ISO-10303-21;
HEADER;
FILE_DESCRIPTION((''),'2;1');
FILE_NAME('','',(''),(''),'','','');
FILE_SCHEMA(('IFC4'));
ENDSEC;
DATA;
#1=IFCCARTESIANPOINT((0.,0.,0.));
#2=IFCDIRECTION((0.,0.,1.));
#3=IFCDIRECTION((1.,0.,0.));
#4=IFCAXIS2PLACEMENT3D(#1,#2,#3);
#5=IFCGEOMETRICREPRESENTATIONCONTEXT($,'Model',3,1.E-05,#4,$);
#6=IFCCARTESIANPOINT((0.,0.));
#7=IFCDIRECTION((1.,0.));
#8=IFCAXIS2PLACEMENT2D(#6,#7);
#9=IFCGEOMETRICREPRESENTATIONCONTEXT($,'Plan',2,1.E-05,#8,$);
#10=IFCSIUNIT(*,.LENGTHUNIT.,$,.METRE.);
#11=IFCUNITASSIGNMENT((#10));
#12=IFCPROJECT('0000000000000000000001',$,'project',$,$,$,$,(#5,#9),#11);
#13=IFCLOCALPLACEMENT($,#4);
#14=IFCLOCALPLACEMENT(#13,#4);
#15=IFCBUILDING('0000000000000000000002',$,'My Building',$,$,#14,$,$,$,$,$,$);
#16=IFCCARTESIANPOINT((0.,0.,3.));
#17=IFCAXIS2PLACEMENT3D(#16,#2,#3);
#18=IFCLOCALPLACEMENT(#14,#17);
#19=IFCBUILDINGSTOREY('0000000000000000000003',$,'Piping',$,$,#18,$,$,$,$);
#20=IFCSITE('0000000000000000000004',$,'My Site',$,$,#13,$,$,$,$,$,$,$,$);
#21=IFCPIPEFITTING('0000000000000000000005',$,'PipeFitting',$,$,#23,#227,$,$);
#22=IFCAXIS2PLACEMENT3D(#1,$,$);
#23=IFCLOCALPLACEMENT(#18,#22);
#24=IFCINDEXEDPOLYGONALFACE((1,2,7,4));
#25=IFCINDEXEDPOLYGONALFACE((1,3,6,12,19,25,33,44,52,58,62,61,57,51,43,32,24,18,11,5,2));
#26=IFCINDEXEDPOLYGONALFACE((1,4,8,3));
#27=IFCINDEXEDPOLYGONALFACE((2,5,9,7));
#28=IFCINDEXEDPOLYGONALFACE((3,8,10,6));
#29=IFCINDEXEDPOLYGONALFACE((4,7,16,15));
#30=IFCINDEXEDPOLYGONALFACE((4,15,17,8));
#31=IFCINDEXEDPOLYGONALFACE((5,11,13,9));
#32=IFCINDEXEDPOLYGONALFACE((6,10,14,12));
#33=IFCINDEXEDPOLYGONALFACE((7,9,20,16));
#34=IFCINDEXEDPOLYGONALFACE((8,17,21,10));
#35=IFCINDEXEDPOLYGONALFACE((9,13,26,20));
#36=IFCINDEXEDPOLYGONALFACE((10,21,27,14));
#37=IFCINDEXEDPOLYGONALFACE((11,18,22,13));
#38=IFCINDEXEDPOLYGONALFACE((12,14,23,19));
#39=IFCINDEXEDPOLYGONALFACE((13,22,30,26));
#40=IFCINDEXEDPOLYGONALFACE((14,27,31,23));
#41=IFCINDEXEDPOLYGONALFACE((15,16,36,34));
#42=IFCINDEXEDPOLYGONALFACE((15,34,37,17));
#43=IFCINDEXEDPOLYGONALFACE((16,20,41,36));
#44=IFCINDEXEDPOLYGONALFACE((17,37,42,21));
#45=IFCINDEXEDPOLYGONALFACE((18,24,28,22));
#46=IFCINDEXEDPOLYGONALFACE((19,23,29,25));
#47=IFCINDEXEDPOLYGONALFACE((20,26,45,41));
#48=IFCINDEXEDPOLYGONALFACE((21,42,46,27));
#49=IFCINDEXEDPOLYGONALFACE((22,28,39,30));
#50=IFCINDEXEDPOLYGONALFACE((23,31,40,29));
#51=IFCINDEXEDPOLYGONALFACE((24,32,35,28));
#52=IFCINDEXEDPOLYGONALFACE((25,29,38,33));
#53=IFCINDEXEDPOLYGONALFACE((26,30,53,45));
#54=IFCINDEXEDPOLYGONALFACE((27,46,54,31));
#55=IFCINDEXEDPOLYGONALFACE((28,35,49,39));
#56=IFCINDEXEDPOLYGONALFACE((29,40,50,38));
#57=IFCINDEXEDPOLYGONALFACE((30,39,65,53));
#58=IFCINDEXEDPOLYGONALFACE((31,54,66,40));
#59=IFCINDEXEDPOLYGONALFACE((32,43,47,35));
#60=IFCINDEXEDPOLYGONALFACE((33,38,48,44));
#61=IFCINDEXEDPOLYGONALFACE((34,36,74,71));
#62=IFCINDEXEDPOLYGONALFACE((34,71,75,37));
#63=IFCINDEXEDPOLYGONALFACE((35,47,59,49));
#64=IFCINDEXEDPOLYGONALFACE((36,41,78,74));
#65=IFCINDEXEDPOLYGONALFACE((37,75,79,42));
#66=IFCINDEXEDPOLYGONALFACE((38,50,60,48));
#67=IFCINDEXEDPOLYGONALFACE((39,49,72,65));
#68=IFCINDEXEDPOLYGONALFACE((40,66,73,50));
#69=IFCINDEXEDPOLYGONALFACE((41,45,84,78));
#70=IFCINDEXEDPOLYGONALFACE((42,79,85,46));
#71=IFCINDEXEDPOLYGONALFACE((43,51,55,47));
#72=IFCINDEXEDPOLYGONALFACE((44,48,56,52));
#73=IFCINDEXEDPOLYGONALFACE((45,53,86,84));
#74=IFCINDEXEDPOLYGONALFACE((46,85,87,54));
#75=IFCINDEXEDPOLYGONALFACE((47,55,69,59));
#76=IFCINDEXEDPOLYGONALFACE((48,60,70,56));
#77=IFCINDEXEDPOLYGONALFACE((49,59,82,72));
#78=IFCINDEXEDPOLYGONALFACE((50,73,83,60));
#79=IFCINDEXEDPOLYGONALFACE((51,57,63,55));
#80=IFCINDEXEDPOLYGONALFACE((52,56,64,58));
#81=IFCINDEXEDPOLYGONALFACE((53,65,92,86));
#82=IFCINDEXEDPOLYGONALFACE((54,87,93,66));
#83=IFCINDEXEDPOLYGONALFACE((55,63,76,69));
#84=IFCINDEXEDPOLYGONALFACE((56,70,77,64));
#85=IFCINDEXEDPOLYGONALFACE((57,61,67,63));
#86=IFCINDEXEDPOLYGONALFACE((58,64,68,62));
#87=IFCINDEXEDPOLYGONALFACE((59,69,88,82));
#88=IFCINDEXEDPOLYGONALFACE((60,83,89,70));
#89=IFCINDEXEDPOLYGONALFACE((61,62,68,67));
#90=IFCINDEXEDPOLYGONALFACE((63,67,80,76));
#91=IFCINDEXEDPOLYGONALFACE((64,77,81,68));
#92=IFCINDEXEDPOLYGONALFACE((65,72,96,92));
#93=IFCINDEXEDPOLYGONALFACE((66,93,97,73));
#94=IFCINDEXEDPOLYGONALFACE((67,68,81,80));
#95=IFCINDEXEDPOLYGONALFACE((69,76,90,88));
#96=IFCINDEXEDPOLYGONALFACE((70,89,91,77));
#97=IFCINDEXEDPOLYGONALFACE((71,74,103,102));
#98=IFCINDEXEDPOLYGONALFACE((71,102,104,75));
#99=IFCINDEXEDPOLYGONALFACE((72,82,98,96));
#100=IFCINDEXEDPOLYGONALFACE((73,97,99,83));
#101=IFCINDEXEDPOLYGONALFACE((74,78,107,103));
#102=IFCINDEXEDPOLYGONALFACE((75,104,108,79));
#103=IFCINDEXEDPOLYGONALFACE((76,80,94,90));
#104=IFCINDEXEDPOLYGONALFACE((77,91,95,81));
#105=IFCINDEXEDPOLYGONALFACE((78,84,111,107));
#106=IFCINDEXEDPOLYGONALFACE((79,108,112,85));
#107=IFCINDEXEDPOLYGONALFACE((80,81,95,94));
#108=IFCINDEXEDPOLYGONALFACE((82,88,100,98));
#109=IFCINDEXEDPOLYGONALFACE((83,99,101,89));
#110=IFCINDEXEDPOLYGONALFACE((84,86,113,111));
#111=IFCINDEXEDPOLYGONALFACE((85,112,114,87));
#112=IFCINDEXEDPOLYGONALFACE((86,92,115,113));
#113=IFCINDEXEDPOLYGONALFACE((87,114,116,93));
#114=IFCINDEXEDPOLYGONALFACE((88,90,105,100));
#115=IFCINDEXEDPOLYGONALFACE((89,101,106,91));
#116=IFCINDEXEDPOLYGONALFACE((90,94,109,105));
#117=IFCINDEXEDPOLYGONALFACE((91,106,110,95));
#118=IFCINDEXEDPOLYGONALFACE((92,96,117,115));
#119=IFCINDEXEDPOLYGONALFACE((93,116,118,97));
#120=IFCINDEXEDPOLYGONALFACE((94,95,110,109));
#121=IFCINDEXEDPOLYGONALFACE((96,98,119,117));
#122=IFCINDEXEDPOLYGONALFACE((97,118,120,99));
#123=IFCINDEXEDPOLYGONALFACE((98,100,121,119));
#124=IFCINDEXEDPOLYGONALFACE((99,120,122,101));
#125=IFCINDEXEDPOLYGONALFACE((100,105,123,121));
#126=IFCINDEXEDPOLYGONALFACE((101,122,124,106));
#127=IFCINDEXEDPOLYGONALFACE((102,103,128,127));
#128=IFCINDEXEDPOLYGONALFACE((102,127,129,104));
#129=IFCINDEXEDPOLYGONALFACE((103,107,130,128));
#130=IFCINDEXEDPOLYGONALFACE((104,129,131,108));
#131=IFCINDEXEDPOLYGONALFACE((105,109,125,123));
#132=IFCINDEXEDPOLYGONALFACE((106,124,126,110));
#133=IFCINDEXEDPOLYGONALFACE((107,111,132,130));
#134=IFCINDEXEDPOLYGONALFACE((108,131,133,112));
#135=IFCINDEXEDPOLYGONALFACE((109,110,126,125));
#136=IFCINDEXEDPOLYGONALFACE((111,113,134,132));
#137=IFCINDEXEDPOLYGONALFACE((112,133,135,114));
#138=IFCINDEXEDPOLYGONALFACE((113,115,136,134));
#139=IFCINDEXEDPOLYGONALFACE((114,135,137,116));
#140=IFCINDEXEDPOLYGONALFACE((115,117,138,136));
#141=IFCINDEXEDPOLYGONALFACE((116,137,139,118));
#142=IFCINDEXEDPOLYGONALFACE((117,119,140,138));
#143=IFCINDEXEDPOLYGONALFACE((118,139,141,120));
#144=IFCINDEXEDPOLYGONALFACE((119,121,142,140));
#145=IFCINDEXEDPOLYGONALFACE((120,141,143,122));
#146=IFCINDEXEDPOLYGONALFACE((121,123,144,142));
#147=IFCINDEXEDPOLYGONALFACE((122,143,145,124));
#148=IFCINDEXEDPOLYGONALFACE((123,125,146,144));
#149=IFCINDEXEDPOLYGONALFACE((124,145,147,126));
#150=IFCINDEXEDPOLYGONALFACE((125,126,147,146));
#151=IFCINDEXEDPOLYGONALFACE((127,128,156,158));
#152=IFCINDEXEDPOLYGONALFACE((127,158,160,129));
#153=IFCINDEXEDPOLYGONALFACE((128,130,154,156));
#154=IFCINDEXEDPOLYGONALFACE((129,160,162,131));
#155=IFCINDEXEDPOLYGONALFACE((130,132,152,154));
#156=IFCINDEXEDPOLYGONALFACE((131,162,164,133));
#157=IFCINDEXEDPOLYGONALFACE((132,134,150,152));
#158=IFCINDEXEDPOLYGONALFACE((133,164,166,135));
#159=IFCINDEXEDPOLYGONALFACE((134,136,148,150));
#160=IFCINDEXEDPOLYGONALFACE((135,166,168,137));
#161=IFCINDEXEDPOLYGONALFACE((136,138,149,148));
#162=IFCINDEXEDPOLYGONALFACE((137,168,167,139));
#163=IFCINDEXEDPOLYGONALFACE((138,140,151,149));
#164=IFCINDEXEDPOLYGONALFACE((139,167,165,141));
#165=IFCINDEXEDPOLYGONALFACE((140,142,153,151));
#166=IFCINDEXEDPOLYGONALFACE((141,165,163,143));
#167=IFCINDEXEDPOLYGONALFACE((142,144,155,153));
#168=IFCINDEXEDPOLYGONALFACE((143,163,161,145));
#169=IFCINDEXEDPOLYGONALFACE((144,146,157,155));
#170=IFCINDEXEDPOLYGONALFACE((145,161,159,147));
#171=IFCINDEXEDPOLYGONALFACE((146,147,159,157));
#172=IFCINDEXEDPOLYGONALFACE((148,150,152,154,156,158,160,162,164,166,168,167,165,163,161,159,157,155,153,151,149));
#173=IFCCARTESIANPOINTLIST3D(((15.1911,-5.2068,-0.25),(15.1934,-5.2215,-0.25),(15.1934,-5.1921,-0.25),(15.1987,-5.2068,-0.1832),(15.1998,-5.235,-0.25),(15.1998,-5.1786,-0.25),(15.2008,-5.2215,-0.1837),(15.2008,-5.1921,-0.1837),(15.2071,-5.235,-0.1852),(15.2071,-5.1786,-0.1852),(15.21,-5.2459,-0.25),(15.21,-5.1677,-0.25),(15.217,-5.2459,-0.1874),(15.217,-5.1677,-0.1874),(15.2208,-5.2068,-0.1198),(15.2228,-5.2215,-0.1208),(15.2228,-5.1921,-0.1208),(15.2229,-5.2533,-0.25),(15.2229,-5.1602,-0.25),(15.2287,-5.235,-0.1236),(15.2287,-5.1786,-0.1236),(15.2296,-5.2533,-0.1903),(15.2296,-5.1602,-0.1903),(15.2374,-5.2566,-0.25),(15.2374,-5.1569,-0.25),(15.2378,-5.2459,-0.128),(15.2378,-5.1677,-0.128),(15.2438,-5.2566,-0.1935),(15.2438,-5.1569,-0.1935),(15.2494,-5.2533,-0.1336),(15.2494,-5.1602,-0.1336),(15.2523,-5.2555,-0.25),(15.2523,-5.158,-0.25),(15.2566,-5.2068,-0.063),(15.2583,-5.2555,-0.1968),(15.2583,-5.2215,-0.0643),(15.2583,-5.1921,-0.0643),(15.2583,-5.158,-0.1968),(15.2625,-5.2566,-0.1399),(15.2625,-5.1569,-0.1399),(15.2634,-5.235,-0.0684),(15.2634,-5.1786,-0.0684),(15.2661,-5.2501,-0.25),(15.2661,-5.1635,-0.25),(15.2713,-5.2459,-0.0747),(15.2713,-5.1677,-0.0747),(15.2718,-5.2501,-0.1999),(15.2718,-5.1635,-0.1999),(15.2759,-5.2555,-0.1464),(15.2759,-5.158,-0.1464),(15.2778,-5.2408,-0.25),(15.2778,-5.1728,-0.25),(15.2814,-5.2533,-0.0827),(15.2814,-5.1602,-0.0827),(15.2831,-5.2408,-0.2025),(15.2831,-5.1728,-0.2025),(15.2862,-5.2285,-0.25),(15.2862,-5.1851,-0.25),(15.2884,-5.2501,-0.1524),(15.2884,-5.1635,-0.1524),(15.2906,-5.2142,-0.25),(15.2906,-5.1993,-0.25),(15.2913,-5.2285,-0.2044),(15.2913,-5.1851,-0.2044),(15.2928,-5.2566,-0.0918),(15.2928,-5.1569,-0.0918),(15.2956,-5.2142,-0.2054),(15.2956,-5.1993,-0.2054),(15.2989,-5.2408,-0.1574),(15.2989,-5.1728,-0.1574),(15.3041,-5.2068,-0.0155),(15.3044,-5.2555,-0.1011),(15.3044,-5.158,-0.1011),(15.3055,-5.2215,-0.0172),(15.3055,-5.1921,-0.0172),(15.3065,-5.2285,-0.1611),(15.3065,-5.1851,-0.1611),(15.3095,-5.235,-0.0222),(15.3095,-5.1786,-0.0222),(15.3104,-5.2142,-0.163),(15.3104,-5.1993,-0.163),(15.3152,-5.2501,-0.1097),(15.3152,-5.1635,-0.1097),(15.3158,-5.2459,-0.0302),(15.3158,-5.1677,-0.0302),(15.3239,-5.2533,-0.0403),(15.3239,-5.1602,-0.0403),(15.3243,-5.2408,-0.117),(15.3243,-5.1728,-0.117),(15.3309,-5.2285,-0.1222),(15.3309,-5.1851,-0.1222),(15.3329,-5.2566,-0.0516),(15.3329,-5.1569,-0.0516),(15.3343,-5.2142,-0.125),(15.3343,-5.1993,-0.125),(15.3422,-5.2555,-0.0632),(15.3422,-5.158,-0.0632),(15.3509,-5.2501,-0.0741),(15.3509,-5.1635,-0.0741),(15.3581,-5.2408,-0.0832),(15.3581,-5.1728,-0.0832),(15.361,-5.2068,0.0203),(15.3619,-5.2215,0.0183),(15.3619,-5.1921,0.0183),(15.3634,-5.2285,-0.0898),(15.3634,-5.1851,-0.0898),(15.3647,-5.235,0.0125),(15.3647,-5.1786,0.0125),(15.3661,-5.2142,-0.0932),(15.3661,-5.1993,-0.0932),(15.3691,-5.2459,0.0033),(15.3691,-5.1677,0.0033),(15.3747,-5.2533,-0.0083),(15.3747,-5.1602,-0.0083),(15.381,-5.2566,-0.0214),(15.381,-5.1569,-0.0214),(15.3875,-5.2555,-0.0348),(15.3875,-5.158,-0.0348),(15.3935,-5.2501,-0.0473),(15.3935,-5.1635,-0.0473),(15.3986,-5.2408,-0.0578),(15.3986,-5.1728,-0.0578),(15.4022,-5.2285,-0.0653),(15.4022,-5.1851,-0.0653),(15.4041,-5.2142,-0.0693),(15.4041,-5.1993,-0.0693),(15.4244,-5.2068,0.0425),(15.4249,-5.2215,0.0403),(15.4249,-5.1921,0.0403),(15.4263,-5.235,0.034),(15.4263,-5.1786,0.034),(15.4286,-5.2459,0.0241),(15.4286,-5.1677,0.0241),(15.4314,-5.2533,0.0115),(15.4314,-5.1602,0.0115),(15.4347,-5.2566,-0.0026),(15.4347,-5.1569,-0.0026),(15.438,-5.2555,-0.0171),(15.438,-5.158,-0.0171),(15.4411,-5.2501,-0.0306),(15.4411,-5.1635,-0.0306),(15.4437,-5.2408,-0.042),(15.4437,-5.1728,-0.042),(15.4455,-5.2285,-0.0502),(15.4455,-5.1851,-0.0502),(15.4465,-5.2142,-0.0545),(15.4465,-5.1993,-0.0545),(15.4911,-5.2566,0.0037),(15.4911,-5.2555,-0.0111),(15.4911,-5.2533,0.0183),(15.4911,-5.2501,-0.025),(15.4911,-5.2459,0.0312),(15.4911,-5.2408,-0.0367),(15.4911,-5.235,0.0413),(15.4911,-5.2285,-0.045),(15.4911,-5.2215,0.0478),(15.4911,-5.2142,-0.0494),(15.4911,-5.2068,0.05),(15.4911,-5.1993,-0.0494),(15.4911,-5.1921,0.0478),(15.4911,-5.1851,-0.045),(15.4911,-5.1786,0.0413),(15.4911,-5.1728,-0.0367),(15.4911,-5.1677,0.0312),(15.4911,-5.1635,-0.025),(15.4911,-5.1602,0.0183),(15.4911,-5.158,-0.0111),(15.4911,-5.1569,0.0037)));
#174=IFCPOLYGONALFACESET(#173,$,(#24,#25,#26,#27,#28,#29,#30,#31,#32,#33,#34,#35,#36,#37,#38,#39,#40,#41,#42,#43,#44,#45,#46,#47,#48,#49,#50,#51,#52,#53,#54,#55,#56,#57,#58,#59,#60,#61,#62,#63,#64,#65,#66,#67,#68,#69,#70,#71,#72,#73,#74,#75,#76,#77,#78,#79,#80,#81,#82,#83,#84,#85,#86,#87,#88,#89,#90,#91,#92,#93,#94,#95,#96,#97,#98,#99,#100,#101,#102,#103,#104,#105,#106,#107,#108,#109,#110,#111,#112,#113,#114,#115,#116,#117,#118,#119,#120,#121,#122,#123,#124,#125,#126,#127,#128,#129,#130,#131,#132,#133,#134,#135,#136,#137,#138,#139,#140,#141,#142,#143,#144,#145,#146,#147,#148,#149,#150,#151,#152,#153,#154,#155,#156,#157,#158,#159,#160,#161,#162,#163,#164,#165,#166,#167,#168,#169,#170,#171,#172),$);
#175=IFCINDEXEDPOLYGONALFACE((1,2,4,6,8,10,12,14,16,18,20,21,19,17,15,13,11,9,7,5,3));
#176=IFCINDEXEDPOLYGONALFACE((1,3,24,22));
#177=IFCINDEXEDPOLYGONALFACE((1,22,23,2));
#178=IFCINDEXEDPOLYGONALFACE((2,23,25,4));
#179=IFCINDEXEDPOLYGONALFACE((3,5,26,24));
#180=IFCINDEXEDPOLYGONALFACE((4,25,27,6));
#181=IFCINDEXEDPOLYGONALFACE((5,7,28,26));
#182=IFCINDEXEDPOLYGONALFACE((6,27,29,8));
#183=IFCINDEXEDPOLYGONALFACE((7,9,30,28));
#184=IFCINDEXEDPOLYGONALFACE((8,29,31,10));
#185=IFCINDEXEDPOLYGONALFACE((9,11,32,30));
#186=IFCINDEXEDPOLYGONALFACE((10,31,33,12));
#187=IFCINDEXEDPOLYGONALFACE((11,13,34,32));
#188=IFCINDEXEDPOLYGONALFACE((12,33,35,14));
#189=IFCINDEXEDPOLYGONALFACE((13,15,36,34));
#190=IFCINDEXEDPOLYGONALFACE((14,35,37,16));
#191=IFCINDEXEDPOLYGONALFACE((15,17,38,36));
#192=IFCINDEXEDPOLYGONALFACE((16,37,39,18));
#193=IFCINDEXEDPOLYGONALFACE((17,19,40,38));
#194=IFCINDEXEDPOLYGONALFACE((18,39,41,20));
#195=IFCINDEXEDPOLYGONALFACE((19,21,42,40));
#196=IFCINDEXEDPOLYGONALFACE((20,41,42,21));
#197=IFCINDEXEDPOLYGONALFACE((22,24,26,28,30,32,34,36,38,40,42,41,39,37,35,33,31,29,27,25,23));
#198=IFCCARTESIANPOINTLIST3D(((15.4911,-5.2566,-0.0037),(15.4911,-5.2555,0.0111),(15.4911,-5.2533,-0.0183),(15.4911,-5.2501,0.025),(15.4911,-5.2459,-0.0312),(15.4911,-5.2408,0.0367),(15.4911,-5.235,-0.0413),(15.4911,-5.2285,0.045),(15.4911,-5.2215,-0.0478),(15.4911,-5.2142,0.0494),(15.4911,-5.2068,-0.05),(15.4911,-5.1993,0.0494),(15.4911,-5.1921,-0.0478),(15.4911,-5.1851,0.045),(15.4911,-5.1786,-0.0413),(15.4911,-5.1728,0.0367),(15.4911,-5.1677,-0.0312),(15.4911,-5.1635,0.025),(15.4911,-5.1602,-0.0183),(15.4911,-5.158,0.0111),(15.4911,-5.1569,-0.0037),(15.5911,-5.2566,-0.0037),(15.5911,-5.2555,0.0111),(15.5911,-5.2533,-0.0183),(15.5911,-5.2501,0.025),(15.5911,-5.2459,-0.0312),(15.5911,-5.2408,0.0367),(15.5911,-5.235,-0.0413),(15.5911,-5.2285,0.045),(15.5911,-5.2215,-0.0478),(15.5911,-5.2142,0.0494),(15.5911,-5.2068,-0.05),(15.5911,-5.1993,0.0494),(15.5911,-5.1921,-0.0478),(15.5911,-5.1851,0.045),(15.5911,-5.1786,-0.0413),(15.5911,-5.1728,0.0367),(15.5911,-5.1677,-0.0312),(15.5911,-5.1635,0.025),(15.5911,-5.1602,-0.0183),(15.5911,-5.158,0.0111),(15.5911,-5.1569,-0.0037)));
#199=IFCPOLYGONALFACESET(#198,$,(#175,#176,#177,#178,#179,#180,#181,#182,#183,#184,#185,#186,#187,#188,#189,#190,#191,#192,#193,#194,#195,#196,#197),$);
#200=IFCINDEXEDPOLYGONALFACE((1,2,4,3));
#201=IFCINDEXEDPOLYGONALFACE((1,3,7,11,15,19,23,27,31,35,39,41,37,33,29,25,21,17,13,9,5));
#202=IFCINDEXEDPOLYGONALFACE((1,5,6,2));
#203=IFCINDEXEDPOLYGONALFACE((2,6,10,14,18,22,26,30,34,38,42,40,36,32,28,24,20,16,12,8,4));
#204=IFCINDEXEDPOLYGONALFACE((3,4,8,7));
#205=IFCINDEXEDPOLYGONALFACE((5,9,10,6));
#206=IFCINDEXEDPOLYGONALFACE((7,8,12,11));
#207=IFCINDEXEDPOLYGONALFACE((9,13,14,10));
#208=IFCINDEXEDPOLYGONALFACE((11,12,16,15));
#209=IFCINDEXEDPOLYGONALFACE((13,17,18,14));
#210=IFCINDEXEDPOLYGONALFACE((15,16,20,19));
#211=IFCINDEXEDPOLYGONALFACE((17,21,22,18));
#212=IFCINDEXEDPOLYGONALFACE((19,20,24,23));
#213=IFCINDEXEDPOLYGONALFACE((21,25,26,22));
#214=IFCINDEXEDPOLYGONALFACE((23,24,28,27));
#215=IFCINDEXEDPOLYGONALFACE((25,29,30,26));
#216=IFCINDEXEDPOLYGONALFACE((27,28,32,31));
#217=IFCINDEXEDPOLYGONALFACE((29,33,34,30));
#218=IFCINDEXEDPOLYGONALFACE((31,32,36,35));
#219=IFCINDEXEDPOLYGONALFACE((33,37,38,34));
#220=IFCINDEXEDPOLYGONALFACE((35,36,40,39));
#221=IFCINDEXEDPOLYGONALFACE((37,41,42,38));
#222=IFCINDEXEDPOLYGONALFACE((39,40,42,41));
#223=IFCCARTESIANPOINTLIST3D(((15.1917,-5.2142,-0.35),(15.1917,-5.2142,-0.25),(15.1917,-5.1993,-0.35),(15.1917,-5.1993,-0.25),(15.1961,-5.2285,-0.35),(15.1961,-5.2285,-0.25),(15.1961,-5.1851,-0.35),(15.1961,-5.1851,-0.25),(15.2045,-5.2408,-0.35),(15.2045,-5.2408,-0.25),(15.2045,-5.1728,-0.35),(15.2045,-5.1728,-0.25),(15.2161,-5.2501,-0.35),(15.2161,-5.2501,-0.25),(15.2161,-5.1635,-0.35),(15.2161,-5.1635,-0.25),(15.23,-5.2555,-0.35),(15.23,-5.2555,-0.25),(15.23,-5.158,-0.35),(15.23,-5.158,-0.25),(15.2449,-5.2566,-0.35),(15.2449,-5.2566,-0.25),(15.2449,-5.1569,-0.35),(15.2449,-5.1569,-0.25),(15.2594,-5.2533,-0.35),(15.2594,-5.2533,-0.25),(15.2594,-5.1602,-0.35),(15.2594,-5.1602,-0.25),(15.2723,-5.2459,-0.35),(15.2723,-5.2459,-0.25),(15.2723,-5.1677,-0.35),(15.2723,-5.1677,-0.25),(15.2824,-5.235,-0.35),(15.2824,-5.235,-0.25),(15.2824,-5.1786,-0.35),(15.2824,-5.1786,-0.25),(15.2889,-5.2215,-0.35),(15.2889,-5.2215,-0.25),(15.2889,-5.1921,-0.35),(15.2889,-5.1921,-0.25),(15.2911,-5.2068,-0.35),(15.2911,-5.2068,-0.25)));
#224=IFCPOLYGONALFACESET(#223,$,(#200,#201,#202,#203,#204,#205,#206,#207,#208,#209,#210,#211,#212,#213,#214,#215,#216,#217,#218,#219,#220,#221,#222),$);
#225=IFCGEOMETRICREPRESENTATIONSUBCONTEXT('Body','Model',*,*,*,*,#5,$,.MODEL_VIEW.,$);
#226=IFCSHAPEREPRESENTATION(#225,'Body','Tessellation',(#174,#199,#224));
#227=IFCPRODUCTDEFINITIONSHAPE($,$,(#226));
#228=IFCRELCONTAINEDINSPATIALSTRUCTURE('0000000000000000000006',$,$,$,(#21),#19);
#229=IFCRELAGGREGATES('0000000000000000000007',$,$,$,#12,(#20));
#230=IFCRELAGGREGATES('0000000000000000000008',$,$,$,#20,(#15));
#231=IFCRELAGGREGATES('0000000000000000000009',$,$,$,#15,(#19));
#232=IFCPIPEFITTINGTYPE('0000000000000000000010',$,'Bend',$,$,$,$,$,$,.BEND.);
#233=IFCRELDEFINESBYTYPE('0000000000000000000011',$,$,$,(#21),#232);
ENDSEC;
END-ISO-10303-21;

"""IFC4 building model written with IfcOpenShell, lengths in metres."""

from ifc_helpers import new_model, entity, si_unit, frame, origin_with_axes, origin_2d_with_axis, place, context, subcontext, project, spatial, circle, extrude, source, transform, mapped, type_object, type_shapes, element, save


model = new_model("IFC4")

# Units and contexts
model_context = context("Model", 3, precision=1e-05, world=origin_with_axes())
plan_context = context("Plan", 2, precision=1e-05, world=origin_2d_with_axis())
body_context = subcontext(model_context, "Body", "Model", "MODEL_VIEW")
ifc_project = project(units=[si_unit("LENGTHUNIT", "METRE")], contexts=[model_context, plan_context])

# Site, building, storey
site_placement = place(None, origin_with_axes())
site = spatial("IfcSite", under=ifc_project, at=site_placement, Name="My Site")
building_placement = place(site_placement, origin_with_axes())
building = spatial("IfcBuilding", under=site, at=building_placement, Name="My Building")
storey_placement = place(building_placement, frame((0.0, 0.0, 3.0), z_axis=(0.0, 0.0, 1.0), x_axis=(1.0, 0.0, 0.0)))
storey = spatial("IfcBuildingStorey", under=building, at=storey_placement, Name="Piping")

# Pipe fitting
pipe_fitting_type_1 = type_object("IfcPipeFittingType", Name="Bend", PredefinedType="BEND")
shared_shape_1 = source(origin_with_axes(), body_context, "Body", "SolidModel", [
    entity("IfcSweptDiskSolid", entity("IfcIndexedPolyCurve", entity("IfcCartesianPointList3D", [[0.0, 0.0, -0.1], [0.0732, 0.0, -0.2768], [0.25, 0.0, -0.35]]), [entity("IfcArcIndex", [1, 2, 3])]), 0.05),
    extrude(circle(Radius=0.05), origin_with_axes(), (0.0, 0.0, -1.0), 0.1),
    extrude(circle(Radius=0.05), frame((0.25, 0.0, -0.35), z_axis=(1.0, 0.0, 0.0), x_axis=(0.0, 0.0, 1.0)), (0.0, 0.0, 1.0), 0.1),
])
type_shapes(pipe_fitting_type_1, [shared_shape_1])
for number, where, z_axis, x_axis, name in (
    (1, (15.5911, -5.2068, 0.0), (1.0, 0.0, 0.0), (0.0, 0.0, -1.0), "PipeFitting"),
):
    element("IfcPipeFitting", number, at=place(storey_placement, frame(where, z_axis=z_axis, x_axis=x_axis)), inside=storey, type_object=pipe_fitting_type_1, Name=name, context=body_context, shape_type="MappedRepresentation", body=[
        mapped(shared_shape_1, transform((0.0, 0.0, 0.0), x_axis=(1.0, 0.0, 0.0), y_axis=(0.0, 1.0, 0.0), z_axis=(0.0, 0.0, 1.0), scale=1.0)),
    ])

save(model, "model.ifc")
